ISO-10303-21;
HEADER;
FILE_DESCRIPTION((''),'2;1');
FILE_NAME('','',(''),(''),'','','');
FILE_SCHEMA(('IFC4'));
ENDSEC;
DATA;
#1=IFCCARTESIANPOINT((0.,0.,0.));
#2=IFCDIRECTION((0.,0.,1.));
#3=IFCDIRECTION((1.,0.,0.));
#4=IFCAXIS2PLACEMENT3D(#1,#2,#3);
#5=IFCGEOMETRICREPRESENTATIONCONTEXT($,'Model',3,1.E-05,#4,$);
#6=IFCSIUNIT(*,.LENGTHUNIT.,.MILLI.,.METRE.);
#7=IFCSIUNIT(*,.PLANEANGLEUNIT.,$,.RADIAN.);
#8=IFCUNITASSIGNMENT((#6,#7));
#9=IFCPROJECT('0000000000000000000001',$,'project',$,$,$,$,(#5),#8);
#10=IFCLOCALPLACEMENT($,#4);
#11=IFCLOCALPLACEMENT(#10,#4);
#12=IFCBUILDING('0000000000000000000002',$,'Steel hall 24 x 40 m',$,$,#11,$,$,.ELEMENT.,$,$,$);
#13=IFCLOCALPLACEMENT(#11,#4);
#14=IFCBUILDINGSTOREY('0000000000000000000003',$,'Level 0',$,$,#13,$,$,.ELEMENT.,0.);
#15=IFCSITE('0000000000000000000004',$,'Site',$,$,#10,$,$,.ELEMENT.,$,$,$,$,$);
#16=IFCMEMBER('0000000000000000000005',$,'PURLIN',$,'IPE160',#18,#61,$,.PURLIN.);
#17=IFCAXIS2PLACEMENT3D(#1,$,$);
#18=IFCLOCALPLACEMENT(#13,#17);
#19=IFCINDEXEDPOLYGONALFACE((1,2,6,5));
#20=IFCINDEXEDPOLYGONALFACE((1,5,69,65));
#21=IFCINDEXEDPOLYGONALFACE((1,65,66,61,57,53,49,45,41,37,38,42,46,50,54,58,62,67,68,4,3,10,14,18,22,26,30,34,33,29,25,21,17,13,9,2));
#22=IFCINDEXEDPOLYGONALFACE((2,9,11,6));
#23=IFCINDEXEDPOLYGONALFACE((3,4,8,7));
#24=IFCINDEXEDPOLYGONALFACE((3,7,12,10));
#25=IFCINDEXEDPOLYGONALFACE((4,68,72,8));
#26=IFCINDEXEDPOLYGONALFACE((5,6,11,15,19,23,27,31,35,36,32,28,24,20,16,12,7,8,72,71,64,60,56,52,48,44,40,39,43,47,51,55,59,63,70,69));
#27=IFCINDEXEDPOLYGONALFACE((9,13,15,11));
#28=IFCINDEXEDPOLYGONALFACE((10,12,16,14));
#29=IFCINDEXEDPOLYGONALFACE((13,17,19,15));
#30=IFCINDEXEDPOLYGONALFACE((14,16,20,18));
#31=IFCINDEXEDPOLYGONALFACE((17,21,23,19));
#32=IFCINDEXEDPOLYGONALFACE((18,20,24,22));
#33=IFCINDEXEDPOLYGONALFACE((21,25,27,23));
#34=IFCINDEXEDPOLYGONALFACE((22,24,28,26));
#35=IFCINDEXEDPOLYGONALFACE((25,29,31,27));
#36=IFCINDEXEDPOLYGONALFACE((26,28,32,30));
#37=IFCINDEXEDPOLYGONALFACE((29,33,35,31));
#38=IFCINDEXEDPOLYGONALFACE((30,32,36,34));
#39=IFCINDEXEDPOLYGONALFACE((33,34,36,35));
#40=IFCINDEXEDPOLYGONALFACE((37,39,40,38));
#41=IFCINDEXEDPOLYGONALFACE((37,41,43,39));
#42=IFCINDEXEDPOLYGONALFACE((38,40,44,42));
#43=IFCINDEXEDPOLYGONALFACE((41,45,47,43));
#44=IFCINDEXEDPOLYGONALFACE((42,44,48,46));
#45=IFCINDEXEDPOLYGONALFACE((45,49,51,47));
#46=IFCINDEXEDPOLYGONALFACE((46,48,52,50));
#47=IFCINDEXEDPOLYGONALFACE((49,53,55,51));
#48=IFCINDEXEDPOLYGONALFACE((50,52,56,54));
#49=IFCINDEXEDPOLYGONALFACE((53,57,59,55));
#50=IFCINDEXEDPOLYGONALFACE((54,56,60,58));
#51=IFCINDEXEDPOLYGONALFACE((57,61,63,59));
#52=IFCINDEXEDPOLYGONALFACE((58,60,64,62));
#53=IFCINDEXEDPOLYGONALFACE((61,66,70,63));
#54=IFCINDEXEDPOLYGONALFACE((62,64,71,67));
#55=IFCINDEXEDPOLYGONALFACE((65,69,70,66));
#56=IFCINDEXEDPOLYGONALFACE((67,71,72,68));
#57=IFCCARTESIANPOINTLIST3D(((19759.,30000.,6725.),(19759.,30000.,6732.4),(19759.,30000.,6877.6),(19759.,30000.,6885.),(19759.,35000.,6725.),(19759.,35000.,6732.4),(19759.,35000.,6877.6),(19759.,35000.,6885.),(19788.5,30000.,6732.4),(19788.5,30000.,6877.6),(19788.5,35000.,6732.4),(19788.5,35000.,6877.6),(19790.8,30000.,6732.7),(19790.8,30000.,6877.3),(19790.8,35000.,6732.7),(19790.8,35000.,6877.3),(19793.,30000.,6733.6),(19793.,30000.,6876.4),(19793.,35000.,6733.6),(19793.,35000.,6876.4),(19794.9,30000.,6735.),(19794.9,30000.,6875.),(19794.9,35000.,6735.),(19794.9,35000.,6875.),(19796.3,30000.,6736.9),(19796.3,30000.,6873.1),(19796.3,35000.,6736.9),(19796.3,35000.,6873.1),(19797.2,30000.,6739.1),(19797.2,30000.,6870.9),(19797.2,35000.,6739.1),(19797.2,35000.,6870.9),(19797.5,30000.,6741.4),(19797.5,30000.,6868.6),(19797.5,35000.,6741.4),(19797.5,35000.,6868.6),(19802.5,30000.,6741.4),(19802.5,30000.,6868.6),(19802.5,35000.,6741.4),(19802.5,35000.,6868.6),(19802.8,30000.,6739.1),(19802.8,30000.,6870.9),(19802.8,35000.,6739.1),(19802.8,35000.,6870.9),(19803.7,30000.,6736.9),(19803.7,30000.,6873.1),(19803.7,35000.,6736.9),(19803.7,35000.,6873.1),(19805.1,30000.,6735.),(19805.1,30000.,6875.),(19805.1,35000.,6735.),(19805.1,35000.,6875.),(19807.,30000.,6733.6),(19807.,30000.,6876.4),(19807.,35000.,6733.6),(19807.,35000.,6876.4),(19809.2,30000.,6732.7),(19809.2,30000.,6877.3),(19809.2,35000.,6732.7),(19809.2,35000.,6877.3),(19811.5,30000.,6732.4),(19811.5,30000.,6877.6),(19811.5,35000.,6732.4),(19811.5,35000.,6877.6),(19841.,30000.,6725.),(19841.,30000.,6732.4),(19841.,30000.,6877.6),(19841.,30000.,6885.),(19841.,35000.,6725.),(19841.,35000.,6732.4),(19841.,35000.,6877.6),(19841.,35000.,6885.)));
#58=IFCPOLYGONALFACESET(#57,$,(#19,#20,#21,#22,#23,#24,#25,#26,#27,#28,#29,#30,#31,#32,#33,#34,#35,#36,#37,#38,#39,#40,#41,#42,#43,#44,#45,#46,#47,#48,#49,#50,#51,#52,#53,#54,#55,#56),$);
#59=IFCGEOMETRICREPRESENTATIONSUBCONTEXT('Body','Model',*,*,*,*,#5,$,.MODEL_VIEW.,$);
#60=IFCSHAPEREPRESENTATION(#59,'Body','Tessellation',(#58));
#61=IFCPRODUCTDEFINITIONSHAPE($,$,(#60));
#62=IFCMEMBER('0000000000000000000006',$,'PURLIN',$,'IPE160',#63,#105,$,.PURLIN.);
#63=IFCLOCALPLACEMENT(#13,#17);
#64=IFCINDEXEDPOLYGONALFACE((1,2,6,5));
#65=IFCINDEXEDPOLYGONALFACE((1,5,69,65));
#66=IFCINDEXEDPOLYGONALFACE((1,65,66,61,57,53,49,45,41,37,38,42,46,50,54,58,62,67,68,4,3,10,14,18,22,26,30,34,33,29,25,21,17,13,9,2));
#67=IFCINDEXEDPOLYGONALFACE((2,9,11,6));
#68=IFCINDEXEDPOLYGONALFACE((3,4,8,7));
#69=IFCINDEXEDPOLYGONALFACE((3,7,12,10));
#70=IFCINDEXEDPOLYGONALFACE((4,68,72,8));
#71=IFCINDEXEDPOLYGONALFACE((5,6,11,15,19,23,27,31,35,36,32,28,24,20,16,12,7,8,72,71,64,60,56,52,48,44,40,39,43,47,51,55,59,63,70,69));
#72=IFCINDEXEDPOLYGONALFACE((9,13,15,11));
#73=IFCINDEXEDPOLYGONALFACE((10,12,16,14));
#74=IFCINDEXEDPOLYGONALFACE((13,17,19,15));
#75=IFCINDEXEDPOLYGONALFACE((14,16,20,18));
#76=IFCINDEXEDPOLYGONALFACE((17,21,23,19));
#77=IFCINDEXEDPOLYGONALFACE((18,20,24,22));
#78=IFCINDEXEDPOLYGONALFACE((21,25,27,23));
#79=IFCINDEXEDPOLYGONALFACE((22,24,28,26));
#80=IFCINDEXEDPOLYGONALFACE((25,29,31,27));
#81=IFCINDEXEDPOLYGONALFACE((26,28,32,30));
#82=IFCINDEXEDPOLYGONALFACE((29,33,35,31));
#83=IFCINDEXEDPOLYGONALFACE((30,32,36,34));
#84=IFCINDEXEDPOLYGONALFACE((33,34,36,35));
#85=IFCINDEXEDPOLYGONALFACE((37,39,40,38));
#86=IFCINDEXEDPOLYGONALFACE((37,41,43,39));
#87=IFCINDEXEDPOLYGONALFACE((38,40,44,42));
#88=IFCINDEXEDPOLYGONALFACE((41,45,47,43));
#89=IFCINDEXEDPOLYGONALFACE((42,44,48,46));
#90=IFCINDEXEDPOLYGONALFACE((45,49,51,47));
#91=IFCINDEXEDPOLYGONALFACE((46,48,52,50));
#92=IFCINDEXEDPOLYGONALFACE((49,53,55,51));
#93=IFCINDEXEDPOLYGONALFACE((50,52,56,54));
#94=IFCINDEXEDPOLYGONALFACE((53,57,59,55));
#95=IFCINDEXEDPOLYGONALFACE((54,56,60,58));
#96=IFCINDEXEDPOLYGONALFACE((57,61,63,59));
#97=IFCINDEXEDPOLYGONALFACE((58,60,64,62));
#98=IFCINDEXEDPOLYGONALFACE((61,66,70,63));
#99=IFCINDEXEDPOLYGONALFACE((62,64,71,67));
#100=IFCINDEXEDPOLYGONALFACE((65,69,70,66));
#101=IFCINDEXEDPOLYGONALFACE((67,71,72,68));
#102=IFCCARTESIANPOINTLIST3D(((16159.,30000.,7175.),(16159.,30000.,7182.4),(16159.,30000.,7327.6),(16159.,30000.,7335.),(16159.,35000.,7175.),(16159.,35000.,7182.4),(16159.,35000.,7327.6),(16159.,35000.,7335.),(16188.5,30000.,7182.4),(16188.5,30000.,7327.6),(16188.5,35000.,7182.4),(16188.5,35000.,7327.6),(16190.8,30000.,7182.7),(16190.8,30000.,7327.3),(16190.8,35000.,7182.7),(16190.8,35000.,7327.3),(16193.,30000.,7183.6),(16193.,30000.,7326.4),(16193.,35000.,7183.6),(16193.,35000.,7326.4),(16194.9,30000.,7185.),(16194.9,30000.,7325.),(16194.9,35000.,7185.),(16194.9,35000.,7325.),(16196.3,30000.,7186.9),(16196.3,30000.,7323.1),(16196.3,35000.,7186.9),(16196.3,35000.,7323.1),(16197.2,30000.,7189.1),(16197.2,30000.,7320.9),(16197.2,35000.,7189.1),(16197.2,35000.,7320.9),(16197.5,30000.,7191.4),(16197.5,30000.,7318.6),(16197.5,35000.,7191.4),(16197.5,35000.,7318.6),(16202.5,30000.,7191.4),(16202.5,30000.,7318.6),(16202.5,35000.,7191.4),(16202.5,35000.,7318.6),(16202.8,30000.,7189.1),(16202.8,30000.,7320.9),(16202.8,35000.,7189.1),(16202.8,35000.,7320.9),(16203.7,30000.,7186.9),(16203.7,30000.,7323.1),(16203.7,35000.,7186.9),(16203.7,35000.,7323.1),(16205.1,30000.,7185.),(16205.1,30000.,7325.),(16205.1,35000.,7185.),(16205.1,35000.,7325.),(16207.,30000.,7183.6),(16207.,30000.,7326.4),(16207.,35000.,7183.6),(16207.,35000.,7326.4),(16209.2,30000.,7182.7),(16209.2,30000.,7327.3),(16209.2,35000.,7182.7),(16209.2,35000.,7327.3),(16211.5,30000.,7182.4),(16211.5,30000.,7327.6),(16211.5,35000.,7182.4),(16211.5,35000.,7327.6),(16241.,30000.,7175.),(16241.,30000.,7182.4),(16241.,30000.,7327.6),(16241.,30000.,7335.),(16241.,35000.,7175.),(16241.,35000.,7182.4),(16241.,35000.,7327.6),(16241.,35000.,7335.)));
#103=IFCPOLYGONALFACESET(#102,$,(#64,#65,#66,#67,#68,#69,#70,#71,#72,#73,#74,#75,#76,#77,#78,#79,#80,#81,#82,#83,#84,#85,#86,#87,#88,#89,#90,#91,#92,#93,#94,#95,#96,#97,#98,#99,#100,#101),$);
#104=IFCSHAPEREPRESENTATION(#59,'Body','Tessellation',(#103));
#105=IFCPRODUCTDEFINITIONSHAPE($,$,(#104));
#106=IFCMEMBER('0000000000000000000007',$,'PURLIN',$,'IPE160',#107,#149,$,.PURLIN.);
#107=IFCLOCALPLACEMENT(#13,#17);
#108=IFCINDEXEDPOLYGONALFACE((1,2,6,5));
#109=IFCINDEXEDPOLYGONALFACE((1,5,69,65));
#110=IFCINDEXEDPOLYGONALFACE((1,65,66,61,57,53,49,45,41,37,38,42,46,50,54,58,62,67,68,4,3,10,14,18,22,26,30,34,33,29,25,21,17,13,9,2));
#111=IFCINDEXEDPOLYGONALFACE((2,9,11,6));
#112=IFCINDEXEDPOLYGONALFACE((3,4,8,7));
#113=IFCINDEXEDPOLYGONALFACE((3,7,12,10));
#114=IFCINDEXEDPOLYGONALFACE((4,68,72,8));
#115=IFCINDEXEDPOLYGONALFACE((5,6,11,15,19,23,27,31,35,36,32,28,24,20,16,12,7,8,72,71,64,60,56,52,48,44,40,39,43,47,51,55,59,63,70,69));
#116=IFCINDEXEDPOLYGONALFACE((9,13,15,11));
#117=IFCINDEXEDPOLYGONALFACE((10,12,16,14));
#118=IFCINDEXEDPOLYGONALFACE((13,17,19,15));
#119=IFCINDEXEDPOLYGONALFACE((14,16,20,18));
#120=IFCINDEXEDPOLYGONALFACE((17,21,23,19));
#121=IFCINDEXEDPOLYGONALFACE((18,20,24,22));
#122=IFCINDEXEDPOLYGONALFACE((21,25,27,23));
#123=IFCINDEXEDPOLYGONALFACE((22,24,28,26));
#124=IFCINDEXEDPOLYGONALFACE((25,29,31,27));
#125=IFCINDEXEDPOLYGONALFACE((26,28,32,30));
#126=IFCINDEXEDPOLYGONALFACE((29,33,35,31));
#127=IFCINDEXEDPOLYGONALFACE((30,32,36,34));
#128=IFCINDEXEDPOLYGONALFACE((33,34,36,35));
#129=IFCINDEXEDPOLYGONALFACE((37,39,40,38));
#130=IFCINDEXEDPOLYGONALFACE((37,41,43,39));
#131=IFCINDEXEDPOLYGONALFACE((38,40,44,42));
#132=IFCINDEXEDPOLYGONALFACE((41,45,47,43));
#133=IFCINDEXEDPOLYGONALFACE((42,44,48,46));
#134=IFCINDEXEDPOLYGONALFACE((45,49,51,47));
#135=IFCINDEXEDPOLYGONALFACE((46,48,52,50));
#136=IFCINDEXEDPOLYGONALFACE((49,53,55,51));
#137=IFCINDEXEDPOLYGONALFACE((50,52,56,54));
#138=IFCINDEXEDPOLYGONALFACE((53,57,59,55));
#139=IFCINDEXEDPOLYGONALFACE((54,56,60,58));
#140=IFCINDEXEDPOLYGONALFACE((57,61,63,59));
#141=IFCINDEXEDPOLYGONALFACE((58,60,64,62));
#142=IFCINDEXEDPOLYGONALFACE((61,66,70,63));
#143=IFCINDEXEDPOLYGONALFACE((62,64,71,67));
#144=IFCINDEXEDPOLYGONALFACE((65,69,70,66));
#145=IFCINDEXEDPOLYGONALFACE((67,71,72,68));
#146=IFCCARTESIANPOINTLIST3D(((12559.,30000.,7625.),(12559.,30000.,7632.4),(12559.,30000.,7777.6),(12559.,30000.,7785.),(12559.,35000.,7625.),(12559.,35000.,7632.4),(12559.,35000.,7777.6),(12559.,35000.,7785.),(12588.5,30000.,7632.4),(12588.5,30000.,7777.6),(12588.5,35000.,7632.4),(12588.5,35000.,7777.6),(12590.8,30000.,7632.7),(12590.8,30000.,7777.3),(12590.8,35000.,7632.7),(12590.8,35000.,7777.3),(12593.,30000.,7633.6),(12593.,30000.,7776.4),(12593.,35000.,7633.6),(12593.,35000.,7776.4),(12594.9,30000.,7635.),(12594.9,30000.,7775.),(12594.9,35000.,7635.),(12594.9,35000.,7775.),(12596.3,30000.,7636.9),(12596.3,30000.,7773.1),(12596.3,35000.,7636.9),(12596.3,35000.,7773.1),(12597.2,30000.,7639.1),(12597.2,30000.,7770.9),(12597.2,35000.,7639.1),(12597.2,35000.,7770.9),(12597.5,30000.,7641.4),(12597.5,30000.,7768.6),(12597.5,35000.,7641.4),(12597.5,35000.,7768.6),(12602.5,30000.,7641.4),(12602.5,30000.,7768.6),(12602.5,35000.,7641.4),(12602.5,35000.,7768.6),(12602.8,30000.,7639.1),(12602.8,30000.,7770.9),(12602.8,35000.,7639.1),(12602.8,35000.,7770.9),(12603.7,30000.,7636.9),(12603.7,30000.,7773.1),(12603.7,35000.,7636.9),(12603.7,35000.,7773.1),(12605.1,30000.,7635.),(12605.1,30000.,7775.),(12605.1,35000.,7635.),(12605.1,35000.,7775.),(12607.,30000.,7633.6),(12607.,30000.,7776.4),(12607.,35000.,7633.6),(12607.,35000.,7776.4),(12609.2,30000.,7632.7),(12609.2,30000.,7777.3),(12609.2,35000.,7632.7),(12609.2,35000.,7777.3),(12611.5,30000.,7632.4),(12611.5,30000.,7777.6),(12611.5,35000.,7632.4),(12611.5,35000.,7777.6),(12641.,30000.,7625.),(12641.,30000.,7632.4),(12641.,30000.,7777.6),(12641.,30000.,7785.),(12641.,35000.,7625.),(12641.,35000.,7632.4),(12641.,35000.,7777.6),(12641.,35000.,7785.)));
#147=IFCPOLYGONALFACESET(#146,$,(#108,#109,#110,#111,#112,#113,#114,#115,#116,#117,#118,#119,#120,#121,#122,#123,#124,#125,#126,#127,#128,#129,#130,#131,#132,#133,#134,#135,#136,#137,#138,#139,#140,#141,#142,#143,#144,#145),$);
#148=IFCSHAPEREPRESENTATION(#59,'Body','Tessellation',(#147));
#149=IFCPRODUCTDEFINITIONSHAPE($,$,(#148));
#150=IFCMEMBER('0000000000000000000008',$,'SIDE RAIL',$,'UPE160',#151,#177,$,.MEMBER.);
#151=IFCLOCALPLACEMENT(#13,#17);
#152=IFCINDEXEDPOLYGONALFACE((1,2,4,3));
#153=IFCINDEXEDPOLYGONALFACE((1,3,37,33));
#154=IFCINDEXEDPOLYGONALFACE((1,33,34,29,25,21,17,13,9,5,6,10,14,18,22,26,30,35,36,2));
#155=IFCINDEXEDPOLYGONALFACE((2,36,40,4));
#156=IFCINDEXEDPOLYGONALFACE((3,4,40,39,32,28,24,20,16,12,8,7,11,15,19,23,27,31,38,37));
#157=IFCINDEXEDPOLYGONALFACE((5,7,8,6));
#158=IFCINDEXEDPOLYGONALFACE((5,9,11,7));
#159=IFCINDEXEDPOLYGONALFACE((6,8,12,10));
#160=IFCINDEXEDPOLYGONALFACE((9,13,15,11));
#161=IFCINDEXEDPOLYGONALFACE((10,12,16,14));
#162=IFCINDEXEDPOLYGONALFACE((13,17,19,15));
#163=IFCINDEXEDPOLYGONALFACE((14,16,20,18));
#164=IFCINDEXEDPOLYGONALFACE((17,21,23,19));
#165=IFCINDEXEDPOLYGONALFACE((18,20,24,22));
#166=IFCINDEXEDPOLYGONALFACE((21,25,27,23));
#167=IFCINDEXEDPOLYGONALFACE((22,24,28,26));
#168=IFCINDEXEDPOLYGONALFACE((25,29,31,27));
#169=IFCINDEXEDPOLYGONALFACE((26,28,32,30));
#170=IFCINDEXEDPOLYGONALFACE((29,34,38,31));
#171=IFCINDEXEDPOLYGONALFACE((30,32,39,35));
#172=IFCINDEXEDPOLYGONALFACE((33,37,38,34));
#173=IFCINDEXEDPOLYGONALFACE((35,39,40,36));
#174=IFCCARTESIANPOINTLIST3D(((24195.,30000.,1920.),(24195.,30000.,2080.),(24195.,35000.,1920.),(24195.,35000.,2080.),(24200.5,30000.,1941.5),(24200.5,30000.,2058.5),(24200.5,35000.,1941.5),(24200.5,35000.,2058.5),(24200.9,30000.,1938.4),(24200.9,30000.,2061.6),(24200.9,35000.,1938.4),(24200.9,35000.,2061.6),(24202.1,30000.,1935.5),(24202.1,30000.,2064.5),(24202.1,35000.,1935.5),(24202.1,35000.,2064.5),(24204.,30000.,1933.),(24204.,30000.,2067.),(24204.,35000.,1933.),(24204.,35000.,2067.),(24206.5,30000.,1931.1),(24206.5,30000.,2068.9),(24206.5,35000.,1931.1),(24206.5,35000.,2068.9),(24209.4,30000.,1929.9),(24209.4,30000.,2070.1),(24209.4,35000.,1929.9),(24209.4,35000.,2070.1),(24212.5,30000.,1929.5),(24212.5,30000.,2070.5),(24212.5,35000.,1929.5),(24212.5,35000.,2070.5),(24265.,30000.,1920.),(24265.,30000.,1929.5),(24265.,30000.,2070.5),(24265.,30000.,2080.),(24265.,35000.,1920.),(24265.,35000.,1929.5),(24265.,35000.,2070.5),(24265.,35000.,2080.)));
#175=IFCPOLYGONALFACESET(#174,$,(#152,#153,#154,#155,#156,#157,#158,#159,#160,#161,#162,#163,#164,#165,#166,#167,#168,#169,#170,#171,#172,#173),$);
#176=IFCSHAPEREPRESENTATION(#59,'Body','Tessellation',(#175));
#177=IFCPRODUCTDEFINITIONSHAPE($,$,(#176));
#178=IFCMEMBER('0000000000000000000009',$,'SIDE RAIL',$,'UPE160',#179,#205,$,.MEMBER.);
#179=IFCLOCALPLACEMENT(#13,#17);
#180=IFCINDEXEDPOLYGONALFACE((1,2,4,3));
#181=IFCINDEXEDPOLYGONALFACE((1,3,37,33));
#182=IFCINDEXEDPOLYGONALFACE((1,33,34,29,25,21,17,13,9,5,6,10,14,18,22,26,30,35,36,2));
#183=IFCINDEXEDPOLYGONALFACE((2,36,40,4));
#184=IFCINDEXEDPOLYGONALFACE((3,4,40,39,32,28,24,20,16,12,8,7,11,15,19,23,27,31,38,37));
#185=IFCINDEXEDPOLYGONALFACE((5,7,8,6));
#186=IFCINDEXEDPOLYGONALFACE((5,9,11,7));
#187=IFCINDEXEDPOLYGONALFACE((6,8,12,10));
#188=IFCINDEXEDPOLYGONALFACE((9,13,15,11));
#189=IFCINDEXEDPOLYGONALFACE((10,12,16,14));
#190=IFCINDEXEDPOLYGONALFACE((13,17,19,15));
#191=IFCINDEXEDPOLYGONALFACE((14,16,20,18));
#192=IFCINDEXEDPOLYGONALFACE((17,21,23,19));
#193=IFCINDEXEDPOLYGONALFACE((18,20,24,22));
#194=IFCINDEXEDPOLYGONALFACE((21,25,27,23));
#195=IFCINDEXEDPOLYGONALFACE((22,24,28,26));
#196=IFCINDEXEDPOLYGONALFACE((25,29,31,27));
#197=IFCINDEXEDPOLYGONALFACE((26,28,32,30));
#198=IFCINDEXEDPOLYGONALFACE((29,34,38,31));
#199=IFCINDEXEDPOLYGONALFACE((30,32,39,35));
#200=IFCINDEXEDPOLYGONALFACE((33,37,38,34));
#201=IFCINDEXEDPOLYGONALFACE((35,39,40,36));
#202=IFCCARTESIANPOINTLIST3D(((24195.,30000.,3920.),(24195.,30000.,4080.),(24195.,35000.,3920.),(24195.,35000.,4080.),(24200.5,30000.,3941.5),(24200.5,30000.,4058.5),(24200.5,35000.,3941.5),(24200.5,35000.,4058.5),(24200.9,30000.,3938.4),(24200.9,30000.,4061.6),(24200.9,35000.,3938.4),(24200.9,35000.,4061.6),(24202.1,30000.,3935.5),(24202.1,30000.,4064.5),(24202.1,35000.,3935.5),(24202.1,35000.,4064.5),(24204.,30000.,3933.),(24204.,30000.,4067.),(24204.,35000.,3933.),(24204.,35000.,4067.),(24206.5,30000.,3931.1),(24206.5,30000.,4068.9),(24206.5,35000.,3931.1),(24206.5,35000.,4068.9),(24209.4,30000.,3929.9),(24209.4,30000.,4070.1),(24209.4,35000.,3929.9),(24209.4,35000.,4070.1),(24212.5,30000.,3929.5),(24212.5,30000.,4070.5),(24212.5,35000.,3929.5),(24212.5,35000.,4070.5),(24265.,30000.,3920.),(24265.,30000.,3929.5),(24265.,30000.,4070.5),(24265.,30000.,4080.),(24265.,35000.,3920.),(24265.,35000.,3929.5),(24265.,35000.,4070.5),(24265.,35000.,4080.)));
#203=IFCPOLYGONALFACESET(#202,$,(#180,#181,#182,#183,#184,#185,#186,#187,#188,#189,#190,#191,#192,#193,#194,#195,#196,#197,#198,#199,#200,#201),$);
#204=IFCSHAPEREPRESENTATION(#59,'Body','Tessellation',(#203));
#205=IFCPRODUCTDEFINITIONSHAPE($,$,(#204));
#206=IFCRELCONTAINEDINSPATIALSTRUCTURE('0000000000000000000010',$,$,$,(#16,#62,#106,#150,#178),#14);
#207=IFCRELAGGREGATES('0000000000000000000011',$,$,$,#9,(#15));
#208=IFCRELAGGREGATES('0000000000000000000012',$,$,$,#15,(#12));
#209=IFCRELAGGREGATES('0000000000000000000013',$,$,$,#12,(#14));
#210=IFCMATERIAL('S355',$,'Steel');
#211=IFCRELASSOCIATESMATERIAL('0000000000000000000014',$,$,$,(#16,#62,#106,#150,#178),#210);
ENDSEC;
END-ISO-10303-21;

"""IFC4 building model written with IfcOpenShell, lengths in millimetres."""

from ifc_helpers import new_model, si_unit, frame, origin_with_axes, place, context, subcontext, project, spatial, i_section, u_section, extrude, material, element, save


model = new_model("IFC4")

# Units and contexts
model_context = context("Model", 3, precision=1e-05, world=origin_with_axes())
body_context = subcontext(model_context, "Body", "Model", "MODEL_VIEW")
ifc_project = project(units=[si_unit("LENGTHUNIT", "METRE", prefix="MILLI"), si_unit("PLANEANGLEUNIT", "RADIAN")], contexts=[model_context])

# Site, building, storey
site_placement = place(None, origin_with_axes())
site = spatial("IfcSite", under=ifc_project, at=site_placement, Name="Site", CompositionType="ELEMENT")
building_placement = place(site_placement, origin_with_axes())
building = spatial("IfcBuilding", under=site, at=building_placement, Name="Steel hall 24 x 40 m", CompositionType="ELEMENT")
storey_placement = place(building_placement, origin_with_axes())
storey = spatial("IfcBuildingStorey", under=building, at=storey_placement, Name="Level 0", CompositionType="ELEMENT", Elevation=0.0)

# Shared definitions
ifc_material = material(Name="S355", Category="Steel")

# Members
for number, where, z_axis, x_axis, name in (
    (1, (19800.0, 30000.0, 6805.0), (0.0, 1.0, 0.0), (1.0, 0.0, 0.0), "PURLIN"),
    (2, (16200.0, 30000.0, 7255.0), (0.0, 1.0, 0.0), (1.0, 0.0, 0.0), "PURLIN"),
    (3, (12600.0, 30000.0, 7705.0), (0.0, 1.0, 0.0), (1.0, 0.0, 0.0), "PURLIN"),
):
    element("IfcMember", number, at=place(storey_placement, frame(where, z_axis=z_axis, x_axis=x_axis)), inside=storey, material=ifc_material, Name=name, ObjectType="IPE160", PredefinedType="PURLIN", context=body_context, shape_type="SweptSolid", body=[
        extrude(i_section(OverallWidth=82.0, OverallDepth=160.0, WebThickness=5.0, FlangeThickness=7.4, FilletRadius=9.0), origin_with_axes(), (0.0, 0.0, 1.0), 5000.0),
    ])
for number, where, z_axis, x_axis, name in (
    (4, (24230.0, 30000.0, 2000.0), (0.0, 1.0, 0.0), (1.0, 0.0, 0.0), "SIDE RAIL"),
    (5, (24230.0, 30000.0, 4000.0), (0.0, 1.0, 0.0), (1.0, 0.0, 0.0), "SIDE RAIL"),
):
    element("IfcMember", number, at=place(storey_placement, frame(where, z_axis=z_axis, x_axis=x_axis)), inside=storey, material=ifc_material, Name=name, ObjectType="UPE160", PredefinedType="MEMBER", context=body_context, shape_type="SweptSolid", body=[
        extrude(u_section(Depth=160.0, FlangeWidth=70.0, WebThickness=5.5, FlangeThickness=9.5, FilletRadius=12.0), origin_with_axes(), (0.0, 0.0, 1.0), 5000.0),
    ])

save(model, "model.ifc")
